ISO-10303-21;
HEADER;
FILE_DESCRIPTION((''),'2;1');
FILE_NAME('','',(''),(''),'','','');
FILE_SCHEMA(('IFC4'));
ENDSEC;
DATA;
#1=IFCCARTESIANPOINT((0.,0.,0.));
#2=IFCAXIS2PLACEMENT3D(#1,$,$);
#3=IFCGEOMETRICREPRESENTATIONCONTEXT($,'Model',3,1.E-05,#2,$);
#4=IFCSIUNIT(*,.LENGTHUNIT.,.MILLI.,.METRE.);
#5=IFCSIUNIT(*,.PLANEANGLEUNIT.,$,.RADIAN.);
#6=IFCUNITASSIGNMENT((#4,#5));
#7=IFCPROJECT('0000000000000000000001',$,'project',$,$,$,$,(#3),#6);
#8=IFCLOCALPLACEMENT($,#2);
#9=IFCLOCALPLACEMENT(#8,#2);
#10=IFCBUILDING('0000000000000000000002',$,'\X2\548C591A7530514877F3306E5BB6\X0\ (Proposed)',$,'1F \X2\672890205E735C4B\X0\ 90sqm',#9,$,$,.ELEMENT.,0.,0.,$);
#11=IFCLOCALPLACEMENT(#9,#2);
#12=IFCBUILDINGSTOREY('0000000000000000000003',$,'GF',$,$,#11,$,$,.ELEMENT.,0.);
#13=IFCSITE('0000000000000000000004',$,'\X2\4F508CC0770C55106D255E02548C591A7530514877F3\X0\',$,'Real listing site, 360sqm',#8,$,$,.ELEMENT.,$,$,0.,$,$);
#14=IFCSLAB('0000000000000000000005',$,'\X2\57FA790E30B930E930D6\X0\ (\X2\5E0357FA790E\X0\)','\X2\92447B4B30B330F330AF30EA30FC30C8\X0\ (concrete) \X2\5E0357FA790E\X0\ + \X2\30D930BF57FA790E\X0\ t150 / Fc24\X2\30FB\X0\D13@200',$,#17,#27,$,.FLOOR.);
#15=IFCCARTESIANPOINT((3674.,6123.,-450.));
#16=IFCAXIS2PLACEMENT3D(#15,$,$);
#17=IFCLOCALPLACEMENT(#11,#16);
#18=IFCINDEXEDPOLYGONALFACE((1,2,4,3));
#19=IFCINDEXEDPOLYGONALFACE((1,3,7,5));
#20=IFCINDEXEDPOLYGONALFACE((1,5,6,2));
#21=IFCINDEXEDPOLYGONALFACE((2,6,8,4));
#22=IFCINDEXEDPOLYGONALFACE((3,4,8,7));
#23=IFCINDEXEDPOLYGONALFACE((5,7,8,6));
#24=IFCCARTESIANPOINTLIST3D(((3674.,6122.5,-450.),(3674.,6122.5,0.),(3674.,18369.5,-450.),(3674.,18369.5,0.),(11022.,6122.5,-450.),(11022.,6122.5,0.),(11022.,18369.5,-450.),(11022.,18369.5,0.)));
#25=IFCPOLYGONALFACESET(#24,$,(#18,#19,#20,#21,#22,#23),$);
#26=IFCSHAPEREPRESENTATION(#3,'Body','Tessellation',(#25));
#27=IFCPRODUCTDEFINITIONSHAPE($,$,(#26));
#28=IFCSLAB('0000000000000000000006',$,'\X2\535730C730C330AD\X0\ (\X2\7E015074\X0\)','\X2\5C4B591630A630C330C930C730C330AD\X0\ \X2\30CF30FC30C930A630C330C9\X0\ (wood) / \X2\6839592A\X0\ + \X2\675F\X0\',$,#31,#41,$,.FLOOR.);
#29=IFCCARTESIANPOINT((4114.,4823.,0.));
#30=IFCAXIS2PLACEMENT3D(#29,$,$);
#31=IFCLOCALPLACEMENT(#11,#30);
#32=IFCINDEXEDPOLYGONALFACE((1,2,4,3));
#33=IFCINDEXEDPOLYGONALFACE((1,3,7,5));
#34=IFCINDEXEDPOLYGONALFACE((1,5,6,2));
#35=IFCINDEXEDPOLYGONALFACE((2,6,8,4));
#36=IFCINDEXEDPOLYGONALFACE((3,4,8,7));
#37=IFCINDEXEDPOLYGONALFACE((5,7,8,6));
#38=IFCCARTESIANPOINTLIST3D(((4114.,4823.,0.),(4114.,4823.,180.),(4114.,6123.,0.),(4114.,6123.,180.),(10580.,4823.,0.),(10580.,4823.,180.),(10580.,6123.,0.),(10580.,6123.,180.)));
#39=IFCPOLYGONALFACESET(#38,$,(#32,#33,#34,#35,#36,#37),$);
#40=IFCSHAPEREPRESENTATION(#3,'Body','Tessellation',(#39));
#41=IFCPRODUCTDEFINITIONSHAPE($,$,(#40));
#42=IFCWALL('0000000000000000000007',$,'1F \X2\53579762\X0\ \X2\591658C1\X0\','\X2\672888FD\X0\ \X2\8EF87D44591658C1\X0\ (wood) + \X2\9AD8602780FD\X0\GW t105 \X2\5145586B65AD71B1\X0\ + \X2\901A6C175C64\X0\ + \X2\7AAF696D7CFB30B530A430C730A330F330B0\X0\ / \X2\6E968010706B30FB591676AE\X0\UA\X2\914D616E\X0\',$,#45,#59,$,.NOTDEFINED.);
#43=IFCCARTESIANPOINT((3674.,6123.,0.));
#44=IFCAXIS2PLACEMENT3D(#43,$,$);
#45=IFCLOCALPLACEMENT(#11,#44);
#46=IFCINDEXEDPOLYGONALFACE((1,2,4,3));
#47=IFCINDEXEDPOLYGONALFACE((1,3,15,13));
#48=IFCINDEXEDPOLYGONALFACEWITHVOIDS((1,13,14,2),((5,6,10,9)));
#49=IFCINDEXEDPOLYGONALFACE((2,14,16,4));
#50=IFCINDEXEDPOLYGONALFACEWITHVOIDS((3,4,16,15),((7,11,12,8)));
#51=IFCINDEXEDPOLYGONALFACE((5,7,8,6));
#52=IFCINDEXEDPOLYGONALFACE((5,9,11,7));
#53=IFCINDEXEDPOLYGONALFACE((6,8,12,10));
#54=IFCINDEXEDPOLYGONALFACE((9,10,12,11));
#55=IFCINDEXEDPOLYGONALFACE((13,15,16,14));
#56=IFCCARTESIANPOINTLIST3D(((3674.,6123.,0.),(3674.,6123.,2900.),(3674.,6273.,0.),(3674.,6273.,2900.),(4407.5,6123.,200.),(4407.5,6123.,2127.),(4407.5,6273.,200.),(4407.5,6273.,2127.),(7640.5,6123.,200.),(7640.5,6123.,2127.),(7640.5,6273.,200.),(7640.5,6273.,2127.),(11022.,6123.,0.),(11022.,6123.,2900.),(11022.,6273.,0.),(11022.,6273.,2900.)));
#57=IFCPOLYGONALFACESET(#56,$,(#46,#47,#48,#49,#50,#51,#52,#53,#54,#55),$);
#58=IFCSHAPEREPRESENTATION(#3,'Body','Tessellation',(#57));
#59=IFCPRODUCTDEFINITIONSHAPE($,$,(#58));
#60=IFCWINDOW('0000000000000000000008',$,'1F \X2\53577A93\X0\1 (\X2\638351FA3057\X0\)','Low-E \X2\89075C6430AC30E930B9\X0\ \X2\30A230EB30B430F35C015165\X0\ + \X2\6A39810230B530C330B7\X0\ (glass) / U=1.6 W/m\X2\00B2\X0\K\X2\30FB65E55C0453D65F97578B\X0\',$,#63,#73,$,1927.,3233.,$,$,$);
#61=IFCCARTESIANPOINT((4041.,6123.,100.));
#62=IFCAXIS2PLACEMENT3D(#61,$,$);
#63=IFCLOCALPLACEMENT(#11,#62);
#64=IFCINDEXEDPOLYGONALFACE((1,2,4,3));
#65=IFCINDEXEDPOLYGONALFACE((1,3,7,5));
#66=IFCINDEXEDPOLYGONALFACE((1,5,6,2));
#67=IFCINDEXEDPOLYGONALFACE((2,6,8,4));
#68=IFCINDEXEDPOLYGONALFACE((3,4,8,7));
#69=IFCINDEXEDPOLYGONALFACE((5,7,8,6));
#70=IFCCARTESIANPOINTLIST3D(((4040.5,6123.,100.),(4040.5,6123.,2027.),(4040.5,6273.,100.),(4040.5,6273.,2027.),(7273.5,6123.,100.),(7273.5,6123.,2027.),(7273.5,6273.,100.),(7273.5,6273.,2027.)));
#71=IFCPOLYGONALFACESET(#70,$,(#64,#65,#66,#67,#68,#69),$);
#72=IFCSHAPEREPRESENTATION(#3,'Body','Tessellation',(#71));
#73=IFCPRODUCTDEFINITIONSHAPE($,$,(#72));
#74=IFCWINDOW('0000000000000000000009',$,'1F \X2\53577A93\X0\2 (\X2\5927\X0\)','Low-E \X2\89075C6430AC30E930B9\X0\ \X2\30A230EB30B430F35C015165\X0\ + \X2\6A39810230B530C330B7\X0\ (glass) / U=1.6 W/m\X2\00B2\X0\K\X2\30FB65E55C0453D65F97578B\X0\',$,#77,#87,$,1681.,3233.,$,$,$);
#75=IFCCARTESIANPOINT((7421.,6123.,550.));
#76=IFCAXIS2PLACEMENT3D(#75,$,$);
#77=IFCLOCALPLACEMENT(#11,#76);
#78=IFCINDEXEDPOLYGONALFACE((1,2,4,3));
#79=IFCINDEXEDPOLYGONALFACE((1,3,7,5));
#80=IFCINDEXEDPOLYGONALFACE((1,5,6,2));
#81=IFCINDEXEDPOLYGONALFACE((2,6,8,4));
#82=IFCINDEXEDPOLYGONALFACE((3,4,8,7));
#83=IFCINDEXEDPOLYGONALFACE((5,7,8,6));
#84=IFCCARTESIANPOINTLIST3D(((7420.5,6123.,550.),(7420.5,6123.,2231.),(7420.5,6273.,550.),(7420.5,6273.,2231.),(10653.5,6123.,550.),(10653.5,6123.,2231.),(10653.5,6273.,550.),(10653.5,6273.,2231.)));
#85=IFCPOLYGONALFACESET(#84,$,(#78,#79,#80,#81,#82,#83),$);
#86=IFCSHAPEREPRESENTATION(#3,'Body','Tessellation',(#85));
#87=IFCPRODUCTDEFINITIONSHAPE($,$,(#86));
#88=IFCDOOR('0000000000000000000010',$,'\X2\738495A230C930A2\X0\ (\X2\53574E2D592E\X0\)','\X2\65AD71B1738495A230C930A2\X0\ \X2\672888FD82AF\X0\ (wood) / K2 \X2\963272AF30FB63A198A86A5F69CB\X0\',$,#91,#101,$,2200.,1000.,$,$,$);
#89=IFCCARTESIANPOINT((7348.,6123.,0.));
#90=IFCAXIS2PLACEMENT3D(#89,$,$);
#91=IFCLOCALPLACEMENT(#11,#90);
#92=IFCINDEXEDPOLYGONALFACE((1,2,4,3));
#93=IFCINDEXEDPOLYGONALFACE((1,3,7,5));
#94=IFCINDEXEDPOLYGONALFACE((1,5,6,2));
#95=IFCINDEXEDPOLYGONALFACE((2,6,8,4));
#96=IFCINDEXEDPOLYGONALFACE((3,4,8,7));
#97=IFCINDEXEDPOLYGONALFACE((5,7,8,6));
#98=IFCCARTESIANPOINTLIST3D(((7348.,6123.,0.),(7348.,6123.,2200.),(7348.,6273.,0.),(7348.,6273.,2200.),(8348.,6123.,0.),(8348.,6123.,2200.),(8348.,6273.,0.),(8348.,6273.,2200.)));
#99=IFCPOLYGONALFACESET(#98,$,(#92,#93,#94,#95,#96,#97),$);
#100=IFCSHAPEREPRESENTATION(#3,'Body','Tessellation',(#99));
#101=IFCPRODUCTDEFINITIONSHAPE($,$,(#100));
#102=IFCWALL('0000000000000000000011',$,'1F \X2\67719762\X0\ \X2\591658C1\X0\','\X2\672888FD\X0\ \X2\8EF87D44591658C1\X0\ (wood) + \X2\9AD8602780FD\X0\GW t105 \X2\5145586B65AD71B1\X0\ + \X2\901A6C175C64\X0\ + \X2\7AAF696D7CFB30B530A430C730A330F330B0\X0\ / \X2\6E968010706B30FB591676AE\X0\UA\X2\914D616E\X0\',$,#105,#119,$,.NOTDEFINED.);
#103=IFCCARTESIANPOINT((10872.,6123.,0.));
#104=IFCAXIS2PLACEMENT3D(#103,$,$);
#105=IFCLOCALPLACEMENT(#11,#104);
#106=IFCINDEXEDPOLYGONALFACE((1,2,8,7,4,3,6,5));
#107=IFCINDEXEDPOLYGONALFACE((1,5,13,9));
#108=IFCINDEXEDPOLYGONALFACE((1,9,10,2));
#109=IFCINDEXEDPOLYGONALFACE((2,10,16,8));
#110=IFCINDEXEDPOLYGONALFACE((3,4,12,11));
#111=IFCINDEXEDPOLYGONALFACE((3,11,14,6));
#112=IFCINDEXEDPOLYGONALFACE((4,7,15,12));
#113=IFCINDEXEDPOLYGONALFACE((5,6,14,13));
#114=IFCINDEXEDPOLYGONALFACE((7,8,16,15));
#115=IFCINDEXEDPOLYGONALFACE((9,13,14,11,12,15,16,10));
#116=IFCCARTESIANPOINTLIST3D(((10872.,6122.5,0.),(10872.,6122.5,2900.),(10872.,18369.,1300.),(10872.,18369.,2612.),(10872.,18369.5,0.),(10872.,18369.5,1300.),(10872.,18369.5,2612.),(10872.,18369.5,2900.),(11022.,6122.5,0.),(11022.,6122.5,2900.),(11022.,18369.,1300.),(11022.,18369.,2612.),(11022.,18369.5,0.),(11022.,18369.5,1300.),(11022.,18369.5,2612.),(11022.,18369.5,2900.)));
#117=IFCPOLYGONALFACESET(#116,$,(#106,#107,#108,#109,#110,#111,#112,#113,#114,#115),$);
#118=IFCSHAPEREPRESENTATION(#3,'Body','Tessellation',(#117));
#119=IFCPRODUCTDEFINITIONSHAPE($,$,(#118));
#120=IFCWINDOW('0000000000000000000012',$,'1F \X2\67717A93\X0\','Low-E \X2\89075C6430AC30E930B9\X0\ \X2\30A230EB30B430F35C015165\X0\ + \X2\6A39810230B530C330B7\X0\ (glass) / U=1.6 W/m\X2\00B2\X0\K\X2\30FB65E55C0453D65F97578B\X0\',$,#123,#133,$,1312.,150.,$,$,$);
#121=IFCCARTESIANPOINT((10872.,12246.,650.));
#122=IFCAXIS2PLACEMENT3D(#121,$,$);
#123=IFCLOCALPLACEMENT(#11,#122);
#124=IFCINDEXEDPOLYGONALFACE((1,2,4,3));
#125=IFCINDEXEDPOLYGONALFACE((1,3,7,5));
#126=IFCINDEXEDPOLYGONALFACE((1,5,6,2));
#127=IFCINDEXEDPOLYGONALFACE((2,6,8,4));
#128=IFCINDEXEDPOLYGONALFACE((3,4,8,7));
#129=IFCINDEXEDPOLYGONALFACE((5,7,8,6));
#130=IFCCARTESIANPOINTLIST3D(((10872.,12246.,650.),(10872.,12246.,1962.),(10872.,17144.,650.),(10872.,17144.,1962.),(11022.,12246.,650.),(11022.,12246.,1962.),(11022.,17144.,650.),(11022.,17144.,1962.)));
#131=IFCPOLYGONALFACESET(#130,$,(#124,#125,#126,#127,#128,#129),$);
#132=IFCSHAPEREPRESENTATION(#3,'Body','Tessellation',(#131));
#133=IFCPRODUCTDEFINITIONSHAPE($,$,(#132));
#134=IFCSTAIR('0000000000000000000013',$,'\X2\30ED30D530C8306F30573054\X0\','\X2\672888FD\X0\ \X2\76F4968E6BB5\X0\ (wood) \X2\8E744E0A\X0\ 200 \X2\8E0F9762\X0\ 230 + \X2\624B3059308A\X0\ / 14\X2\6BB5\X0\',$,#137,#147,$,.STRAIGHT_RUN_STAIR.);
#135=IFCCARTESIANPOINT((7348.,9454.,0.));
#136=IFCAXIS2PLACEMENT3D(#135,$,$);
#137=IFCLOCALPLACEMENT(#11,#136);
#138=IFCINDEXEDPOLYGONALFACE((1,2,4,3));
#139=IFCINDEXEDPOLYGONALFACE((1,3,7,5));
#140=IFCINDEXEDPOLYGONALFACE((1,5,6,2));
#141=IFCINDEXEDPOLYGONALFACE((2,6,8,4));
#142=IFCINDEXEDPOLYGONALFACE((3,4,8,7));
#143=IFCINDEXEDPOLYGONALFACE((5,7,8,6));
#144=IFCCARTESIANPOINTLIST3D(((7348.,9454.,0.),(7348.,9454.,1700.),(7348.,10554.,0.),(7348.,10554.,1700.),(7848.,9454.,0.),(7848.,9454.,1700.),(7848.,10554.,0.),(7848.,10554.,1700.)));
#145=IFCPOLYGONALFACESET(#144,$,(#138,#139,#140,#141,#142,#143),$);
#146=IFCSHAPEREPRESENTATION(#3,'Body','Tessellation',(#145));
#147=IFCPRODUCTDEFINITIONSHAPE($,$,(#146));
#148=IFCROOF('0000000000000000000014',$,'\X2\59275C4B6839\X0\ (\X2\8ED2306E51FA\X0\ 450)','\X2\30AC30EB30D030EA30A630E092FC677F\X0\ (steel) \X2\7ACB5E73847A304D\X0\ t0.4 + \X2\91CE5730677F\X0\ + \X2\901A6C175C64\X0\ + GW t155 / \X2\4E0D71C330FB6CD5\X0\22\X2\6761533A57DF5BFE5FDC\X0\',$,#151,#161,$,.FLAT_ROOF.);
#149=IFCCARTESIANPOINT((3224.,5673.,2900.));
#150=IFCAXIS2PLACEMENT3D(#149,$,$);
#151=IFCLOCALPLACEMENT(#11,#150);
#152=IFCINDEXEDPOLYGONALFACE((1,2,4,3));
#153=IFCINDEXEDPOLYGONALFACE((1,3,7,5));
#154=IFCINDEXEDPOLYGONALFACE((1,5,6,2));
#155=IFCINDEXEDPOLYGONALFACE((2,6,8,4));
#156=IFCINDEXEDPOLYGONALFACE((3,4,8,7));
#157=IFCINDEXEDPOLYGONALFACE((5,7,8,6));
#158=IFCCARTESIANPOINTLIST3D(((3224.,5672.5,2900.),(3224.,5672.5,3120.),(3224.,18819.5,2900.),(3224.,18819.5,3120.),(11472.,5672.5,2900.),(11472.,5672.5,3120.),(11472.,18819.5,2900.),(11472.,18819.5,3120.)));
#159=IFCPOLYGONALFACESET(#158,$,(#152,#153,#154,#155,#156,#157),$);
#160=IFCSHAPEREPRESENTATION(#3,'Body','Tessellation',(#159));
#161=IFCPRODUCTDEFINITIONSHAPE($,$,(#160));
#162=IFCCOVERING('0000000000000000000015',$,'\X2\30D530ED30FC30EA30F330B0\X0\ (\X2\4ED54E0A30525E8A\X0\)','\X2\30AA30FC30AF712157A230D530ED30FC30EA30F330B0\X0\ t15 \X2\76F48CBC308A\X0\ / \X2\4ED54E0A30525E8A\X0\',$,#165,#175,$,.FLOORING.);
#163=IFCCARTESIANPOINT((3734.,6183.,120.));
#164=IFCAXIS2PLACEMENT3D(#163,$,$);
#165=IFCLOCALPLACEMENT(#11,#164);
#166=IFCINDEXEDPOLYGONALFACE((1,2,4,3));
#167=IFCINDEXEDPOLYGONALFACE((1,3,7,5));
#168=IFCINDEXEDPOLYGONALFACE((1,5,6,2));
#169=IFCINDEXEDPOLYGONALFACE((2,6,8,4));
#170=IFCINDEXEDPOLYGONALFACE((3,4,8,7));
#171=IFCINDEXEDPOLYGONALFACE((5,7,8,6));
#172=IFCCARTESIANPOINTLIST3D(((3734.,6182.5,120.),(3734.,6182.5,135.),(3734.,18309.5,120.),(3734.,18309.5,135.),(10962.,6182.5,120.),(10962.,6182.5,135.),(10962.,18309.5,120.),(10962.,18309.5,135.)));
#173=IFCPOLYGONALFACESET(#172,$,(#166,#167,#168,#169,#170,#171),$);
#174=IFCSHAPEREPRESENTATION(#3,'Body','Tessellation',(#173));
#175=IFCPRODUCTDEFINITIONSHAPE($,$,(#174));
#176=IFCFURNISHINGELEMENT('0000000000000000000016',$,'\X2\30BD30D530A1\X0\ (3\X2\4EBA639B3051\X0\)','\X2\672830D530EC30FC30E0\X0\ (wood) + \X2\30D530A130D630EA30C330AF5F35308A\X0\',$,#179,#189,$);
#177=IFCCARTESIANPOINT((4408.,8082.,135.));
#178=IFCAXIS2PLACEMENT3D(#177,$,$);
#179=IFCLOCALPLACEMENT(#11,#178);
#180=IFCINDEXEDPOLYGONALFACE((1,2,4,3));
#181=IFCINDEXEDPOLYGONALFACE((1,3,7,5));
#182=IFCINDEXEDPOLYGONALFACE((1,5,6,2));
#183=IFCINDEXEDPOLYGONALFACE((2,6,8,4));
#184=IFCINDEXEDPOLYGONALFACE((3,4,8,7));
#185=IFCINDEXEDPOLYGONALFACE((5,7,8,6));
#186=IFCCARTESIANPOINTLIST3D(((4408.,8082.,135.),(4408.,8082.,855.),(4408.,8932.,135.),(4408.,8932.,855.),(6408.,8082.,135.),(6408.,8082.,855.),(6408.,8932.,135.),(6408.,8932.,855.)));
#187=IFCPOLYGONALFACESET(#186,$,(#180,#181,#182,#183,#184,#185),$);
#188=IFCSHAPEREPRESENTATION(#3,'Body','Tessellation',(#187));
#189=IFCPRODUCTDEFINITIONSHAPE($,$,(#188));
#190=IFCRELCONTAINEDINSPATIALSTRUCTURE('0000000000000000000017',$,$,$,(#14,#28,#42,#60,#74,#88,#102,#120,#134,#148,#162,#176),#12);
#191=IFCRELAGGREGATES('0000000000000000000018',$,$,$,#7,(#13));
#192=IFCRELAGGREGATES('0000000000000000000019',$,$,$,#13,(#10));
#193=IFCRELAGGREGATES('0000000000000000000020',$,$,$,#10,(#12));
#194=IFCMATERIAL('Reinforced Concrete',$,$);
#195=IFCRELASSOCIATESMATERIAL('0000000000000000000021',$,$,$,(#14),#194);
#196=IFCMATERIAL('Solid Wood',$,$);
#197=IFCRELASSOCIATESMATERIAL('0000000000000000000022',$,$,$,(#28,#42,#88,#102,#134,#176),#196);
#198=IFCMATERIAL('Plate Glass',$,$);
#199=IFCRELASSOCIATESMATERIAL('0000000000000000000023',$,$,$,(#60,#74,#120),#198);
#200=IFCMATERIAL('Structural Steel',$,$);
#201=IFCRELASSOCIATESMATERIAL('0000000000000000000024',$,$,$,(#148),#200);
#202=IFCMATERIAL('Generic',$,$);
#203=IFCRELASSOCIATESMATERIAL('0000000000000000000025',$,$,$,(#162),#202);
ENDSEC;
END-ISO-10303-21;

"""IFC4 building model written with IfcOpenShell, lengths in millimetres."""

from ifc_helpers import new_model, si_unit, frame, frame_2d, origin, place, context, project, spatial, rectangle, extrude, material, element, fill, save


model = new_model("IFC4")

# Units and contexts
model_context = context("Model", 3, precision=1e-05, world=origin())
ifc_project = project(units=[si_unit("LENGTHUNIT", "METRE", prefix="MILLI"), si_unit("PLANEANGLEUNIT", "RADIAN")], contexts=[model_context])

# Site, building, storey
site_placement = place(None, origin())
site = spatial("IfcSite", under=ifc_project, at=site_placement, Name="佐賀県唐津市和多田先石", ObjectType="Real listing site, 360sqm", CompositionType="ELEMENT", RefElevation=0.0)
building_placement = place(site_placement, origin())
building = spatial("IfcBuilding", under=site, at=building_placement, Name="和多田先石の家 (Proposed)", ObjectType="1F 木造平屋 90sqm", CompositionType="ELEMENT", ElevationOfRefHeight=0.0, ElevationOfTerrain=0.0)
storey_placement = place(building_placement, origin())
storey = spatial("IfcBuildingStorey", under=building, at=storey_placement, Name="GF", CompositionType="ELEMENT", Elevation=0.0)

# Slabs
ifc_material_1 = material(Name="Reinforced Concrete")
slab_1_placement = place(storey_placement, frame((3674.0, 6123.0, -450.0)))
element("IfcSlab", 1, at=slab_1_placement, inside=storey, material=ifc_material_1, Name="基礎スラブ (布基礎)", Description="鉄筋コンクリート (concrete) 布基礎 + ベタ基礎 t150 / Fc24・D13@200", PredefinedType="FLOOR", context=model_context, shape_type="SweptSolid", body=[
    extrude(rectangle(XDim=7348.0, YDim=12247.0, at=frame_2d((3674.0, 6123.0))), frame((3674.0, 6123.0, -450.0)), (0.0, 0.0, 1.0), 450.0),
])
ifc_material_2 = material(Name="Solid Wood")
slab_2_placement = place(storey_placement, frame((4114.0, 4823.0, 0.0)))
element("IfcSlab", 2, at=slab_2_placement, inside=storey, material=ifc_material_2, Name="南デッキ (縁側)", Description="屋外ウッドデッキ ハードウッド (wood) / 根太 + 束", PredefinedType="FLOOR", context=model_context, shape_type="SweptSolid", body=[
    extrude(rectangle(XDim=6466.0, YDim=1300.0, at=frame_2d((3233.0, 650.0))), frame((4114.0, 4823.0, 0.0)), (0.0, 0.0, 1.0), 180.0),
])

# Wall, openings, windows, door
wall_1_placement = place(storey_placement, frame((3674.0, 6123.0, 0.0)))
wall_1 = element("IfcWall", 3, at=wall_1_placement, inside=storey, material=ifc_material_2, Name="1F 南面 外壁", Description="木製 軸組外壁 (wood) + 高性能GW t105 充填断熱 + 通気層 + 窯業系サイディング / 準耐火・外皮UA配慮", PredefinedType="NOTDEFINED", context=model_context, shape_type="SweptSolid", body=[
    extrude(rectangle(XDim=7348.0, YDim=150.0, at=frame_2d((3674.0, 75.0))), frame((3674.0, 6123.0, 0.0)), (0.0, 0.0, 1.0), 2900.0),
])
opening_1_placement = place(storey_placement, frame((4041.0, 6123.0, 100.0)))
opening_1 = element("IfcOpeningElement", 4, at=opening_1_placement, cuts=wall_1, PredefinedType="NOTDEFINED", context=model_context, shape_type="SweptSolid", body=[
    extrude(rectangle(XDim=3233.0, YDim=150.0, at=frame_2d((1616.0, 75.0))), frame((4041.0, 6123.0, 100.0)), (0.0, 0.0, 1.0), 1927.0),
])
opening_2_placement = place(storey_placement, frame((7421.0, 6123.0, 550.0)))
opening_2 = element("IfcOpeningElement", 5, at=opening_2_placement, cuts=wall_1, PredefinedType="NOTDEFINED", context=model_context, shape_type="SweptSolid", body=[
    extrude(rectangle(XDim=3233.0, YDim=150.0, at=frame_2d((1616.0, 75.0))), frame((7421.0, 6123.0, 550.0)), (0.0, 0.0, 1.0), 1681.0),
])
opening_3_placement = place(storey_placement, frame((7348.0, 6123.0, 0.0)))
opening_3 = element("IfcOpeningElement", 6, at=opening_3_placement, cuts=wall_1, PredefinedType="NOTDEFINED", context=model_context, shape_type="SweptSolid", body=[
    extrude(rectangle(XDim=1000.0, YDim=150.0, at=frame_2d((500.0, 75.0))), frame((7348.0, 6123.0, 0.0)), (0.0, 0.0, 1.0), 2200.0),
])
ifc_material_3 = material(Name="Plate Glass")
window_1_placement = place(storey_placement, frame((4041.0, 6123.0, 100.0)))
window_1 = element("IfcWindow", 7, at=window_1_placement, inside=storey, material=ifc_material_3, Name="1F 南窓1 (掃出し)", Description="Low-E 複層ガラス アルゴン封入 + 樹脂サッシ (glass) / U=1.6 W/m²K・日射取得型", OverallHeight=1927.0, OverallWidth=3233.0, context=model_context, shape_type="SweptSolid", body=[
    extrude(rectangle(XDim=3233.0, YDim=150.0, at=frame_2d((1616.0, 75.0))), frame((4041.0, 6123.0, 100.0)), (0.0, 0.0, 1.0), 1927.0),
])
fill(opening_1, window_1)
window_2_placement = place(storey_placement, frame((7421.0, 6123.0, 550.0)))
window_2 = element("IfcWindow", 8, at=window_2_placement, inside=storey, material=ifc_material_3, Name="1F 南窓2 (大)", Description="Low-E 複層ガラス アルゴン封入 + 樹脂サッシ (glass) / U=1.6 W/m²K・日射取得型", OverallHeight=1681.0, OverallWidth=3233.0, context=model_context, shape_type="SweptSolid", body=[
    extrude(rectangle(XDim=3233.0, YDim=150.0, at=frame_2d((1616.0, 75.0))), frame((7421.0, 6123.0, 550.0)), (0.0, 0.0, 1.0), 1681.0),
])
fill(opening_2, window_2)
door_placement = place(storey_placement, frame((7348.0, 6123.0, 0.0)))
door = element("IfcDoor", 9, at=door_placement, inside=storey, material=ifc_material_2, Name="玄関ドア (南中央)", Description="断熱玄関ドア 木製芯 (wood) / K2 防犯・採風機構", OverallHeight=2200.0, OverallWidth=1000.0, context=model_context, shape_type="SweptSolid", body=[
    extrude(rectangle(XDim=1000.0, YDim=150.0, at=frame_2d((500.0, 75.0))), frame((7348.0, 6123.0, 0.0)), (0.0, 0.0, 1.0), 2200.0),
])
fill(opening_3, door)

# Wall, opening, window
wall_2_placement = place(storey_placement, frame((10872.0, 6123.0, 0.0)))
wall_2 = element("IfcWall", 10, at=wall_2_placement, inside=storey, material=ifc_material_2, Name="1F 東面 外壁", Description="木製 軸組外壁 (wood) + 高性能GW t105 充填断熱 + 通気層 + 窯業系サイディング / 準耐火・外皮UA配慮", PredefinedType="NOTDEFINED", context=model_context, shape_type="SweptSolid", body=[
    extrude(rectangle(XDim=150.0, YDim=12247.0, at=frame_2d((75.0, 6123.0))), frame((10872.0, 6123.0, 0.0)), (0.0, 0.0, 1.0), 2900.0),
])
opening_4_placement = place(storey_placement, frame((10872.0, 12246.0, 650.0)))
opening_4 = element("IfcOpeningElement", 11, at=opening_4_placement, cuts=wall_2, PredefinedType="NOTDEFINED", context=model_context, shape_type="SweptSolid", body=[
    extrude(rectangle(XDim=150.0, YDim=4898.0, at=frame_2d((75.0, 2449.0))), frame((10872.0, 12246.0, 650.0)), (0.0, 0.0, 1.0), 1312.0),
])
window_3_placement = place(storey_placement, frame((10872.0, 12246.0, 650.0)))
window_3 = element("IfcWindow", 12, at=window_3_placement, inside=storey, material=ifc_material_3, Name="1F 東窓", Description="Low-E 複層ガラス アルゴン封入 + 樹脂サッシ (glass) / U=1.6 W/m²K・日射取得型", OverallHeight=1312.0, OverallWidth=150.0, context=model_context, shape_type="SweptSolid", body=[
    extrude(rectangle(XDim=150.0, YDim=4898.0, at=frame_2d((75.0, 2449.0))), frame((10872.0, 12246.0, 650.0)), (0.0, 0.0, 1.0), 1312.0),
])
fill(opening_4, window_3)

# Stair
stair_placement = place(storey_placement, frame((7348.0, 9454.0, 0.0)))
element("IfcStair", 13, at=stair_placement, inside=storey, material=ifc_material_2, Name="ロフトはしご", Description="木製 直階段 (wood) 蹴上 200 踏面 230 + 手すり / 14段", PredefinedType="STRAIGHT_RUN_STAIR", context=model_context, shape_type="SweptSolid", body=[
    extrude(rectangle(XDim=500.0, YDim=1100.0, at=frame_2d((250.0, 550.0))), frame((7348.0, 9454.0, 0.0)), (0.0, 0.0, 1.0), 1700.0),
])

# Roof
ifc_material_4 = material(Name="Structural Steel")
roof_placement = place(storey_placement, frame((3224.0, 5673.0, 2900.0)))
element("IfcRoof", 14, at=roof_placement, inside=storey, material=ifc_material_4, Name="大屋根 (軒の出 450)", Description="ガルバリウム鋼板 (steel) 立平葺き t0.4 + 野地板 + 通気層 + GW t155 / 不燃・法22条区域対応", PredefinedType="FLAT_ROOF", context=model_context, shape_type="SweptSolid", body=[
    extrude(rectangle(XDim=8248.0, YDim=13147.0, at=frame_2d((4124.0, 6573.0))), frame((3224.0, 5673.0, 2900.0)), (0.0, 0.0, 1.0), 220.0),
])

# Covering
ifc_material_5 = material(Name="Generic")
covering_placement = place(storey_placement, frame((3734.0, 6183.0, 120.0)))
element("IfcCovering", 15, at=covering_placement, inside=storey, material=ifc_material_5, Name="フローリング (仕上げ床)", Description="オーク無垢フローリング t15 直貼り / 仕上げ床", PredefinedType="FLOORING", context=model_context, shape_type="SweptSolid", body=[
    extrude(rectangle(XDim=7228.0, YDim=12127.0, at=frame_2d((3614.0, 6063.0))), frame((3734.0, 6183.0, 120.0)), (0.0, 0.0, 1.0), 15.0),
])

# Furnishing element
furnishing_1_placement = place(storey_placement, frame((4408.0, 8082.0, 135.0)))
element("IfcFurnishingElement", 16, at=furnishing_1_placement, inside=storey, material=ifc_material_2, Name="ソファ (3人掛け)", Description="木フレーム (wood) + ファブリック張り", context=model_context, shape_type="SweptSolid", body=[
    extrude(rectangle(XDim=2000.0, YDim=850.0, at=frame_2d((1000.0, 425.0))), frame((4408.0, 8082.0, 135.0)), (0.0, 0.0, 1.0), 720.0),
])

save(model, "model.ifc")
